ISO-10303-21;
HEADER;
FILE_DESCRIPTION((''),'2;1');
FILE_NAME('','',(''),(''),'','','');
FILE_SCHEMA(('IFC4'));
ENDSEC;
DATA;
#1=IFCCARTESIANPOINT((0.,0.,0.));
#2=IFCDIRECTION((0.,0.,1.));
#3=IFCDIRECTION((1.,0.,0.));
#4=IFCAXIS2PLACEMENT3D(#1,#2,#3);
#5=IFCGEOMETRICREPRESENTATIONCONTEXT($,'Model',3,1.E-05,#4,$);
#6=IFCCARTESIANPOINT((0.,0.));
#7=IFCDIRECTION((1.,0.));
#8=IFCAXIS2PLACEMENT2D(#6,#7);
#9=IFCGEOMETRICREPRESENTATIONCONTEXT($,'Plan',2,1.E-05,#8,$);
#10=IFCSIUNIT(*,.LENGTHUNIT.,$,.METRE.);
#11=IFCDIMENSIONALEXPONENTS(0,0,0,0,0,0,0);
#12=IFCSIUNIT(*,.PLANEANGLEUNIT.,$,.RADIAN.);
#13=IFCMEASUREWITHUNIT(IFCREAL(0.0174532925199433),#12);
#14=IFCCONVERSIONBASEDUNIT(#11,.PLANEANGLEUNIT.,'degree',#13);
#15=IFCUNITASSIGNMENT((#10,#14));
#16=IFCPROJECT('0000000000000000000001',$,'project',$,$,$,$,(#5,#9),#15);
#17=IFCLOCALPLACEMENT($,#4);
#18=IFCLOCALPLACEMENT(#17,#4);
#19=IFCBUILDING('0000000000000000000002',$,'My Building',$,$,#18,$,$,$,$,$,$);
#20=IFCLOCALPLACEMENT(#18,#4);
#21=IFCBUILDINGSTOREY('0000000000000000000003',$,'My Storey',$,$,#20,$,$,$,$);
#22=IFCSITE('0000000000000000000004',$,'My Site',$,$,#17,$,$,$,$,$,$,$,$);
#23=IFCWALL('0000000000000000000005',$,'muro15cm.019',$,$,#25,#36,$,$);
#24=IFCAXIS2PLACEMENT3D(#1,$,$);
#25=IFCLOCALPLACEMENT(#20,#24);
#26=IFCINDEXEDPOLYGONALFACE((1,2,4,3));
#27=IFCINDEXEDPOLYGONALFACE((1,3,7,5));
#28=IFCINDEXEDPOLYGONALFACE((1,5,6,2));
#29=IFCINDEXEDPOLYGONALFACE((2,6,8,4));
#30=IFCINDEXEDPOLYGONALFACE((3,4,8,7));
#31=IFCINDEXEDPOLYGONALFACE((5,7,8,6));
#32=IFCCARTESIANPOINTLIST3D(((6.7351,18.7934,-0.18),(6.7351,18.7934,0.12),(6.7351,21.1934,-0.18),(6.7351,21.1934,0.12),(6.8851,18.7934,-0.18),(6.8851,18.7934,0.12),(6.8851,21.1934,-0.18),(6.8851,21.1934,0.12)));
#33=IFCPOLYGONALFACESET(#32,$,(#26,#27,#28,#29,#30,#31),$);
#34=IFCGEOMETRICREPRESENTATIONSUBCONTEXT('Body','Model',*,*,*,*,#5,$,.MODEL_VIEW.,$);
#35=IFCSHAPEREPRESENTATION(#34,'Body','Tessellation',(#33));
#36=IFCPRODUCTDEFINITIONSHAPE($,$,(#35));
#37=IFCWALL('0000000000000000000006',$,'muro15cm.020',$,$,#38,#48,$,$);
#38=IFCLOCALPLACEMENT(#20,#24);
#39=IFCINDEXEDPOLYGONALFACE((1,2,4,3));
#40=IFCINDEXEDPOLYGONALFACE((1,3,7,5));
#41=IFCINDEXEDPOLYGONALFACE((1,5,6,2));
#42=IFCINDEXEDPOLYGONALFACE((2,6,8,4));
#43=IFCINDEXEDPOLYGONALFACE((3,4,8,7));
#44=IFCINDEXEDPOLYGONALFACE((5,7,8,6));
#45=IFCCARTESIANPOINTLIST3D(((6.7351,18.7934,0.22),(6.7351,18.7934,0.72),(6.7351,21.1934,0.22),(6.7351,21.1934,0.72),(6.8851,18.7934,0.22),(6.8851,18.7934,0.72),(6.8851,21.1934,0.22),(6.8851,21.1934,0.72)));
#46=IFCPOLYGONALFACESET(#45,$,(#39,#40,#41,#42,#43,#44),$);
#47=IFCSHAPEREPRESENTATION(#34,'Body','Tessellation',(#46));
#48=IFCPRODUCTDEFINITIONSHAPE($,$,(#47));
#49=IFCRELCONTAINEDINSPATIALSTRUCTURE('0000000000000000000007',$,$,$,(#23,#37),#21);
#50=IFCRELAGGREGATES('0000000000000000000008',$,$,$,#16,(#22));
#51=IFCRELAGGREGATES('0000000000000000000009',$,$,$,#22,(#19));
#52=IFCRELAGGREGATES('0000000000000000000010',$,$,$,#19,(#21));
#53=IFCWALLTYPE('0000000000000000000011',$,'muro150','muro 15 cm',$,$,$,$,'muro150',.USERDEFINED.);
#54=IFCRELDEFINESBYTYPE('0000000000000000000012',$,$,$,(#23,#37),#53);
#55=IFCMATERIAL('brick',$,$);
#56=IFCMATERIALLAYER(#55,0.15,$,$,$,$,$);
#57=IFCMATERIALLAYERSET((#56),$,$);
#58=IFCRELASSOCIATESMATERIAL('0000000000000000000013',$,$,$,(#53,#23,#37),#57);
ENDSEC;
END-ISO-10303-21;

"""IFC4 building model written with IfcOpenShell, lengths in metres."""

from ifc_helpers import new_model, entity, si_unit, converted_unit, frame, origin_with_axes, origin_2d_with_axis, place, context, subcontext, project, spatial, indexed_curve, outline, extrude, material, layer, layer_set, layer_usage, type_object, element, save


model = new_model("IFC4")

# Units and contexts
model_context = context("Model", 3, precision=1e-05, world=origin_with_axes())
plan_context = context("Plan", 2, precision=1e-05, world=origin_2d_with_axis())
body_context = subcontext(model_context, "Body", "Model", "MODEL_VIEW")
ifc_project = project(units=[si_unit("LENGTHUNIT", "METRE"), converted_unit("PLANEANGLEUNIT", "degree", entity("IfcReal", 0.0174532925199433), si_unit("PLANEANGLEUNIT", "RADIAN"), dimensions=[0, 0, 0, 0, 0, 0, 0])], contexts=[model_context, plan_context])

# Site, building, storey
site_placement = place(None, origin_with_axes())
site = spatial("IfcSite", under=ifc_project, at=site_placement, Name="My Site")
building_placement = place(site_placement, origin_with_axes())
building = spatial("IfcBuilding", under=site, at=building_placement, Name="My Building")
storey_placement = place(building_placement, origin_with_axes())
storey = spatial("IfcBuildingStorey", under=building, at=storey_placement, Name="My Storey")

# Walls
ifc_material_1 = material(Name="brick")
ifc_layer_1 = layer(ifc_material_1, 0.15)
ifc_layer_set_1 = layer_set([ifc_layer_1])
ifc_layer_usage_1 = layer_usage(ifc_layer_set_1, "AXIS2", "POSITIVE", 0.0)
wall_type_1 = type_object("IfcWallType", Name="muro150", Description="muro 15 cm", ElementType="muro150", PredefinedType="USERDEFINED", material=ifc_layer_set_1)
wall_1_placement = place(storey_placement, frame((6.7351, 21.1934, -0.18), z_axis=(0.0, 0.0, 1.0), x_axis=(0.0, -1.0, 0.0)))
element("IfcWall", 1, at=wall_1_placement, inside=storey, type_object=wall_type_1, material=ifc_layer_usage_1, Name="muro15cm.019", context=body_context, shape_type="SweptSolid", body=[
    extrude(outline(indexed_curve([(0.0, 0.0), (0.0, 0.15), (2.4, 0.15), (2.4, 0.0), (0.0, 0.0)], self_intersect=False)), origin_with_axes(), (0.0, 0.0, 1.0), 0.3),
])
ifc_layer_usage_2 = layer_usage(ifc_layer_set_1, "AXIS2", "POSITIVE", 0.0)
wall_2_placement = place(storey_placement, frame((6.7351, 21.1934, 0.22), z_axis=(0.0, 0.0, 1.0), x_axis=(0.0, -1.0, 0.0)))
element("IfcWall", 2, at=wall_2_placement, inside=storey, type_object=wall_type_1, material=ifc_layer_usage_2, Name="muro15cm.020", context=body_context, shape_type="SweptSolid", body=[
    extrude(outline(indexed_curve([(0.0, 0.0), (0.0, 0.15), (2.4, 0.15), (2.4, 0.0), (0.0, 0.0)], self_intersect=False)), origin_with_axes(), (0.0, 0.0, 1.0), 0.5),
])

save(model, "model.ifc")
